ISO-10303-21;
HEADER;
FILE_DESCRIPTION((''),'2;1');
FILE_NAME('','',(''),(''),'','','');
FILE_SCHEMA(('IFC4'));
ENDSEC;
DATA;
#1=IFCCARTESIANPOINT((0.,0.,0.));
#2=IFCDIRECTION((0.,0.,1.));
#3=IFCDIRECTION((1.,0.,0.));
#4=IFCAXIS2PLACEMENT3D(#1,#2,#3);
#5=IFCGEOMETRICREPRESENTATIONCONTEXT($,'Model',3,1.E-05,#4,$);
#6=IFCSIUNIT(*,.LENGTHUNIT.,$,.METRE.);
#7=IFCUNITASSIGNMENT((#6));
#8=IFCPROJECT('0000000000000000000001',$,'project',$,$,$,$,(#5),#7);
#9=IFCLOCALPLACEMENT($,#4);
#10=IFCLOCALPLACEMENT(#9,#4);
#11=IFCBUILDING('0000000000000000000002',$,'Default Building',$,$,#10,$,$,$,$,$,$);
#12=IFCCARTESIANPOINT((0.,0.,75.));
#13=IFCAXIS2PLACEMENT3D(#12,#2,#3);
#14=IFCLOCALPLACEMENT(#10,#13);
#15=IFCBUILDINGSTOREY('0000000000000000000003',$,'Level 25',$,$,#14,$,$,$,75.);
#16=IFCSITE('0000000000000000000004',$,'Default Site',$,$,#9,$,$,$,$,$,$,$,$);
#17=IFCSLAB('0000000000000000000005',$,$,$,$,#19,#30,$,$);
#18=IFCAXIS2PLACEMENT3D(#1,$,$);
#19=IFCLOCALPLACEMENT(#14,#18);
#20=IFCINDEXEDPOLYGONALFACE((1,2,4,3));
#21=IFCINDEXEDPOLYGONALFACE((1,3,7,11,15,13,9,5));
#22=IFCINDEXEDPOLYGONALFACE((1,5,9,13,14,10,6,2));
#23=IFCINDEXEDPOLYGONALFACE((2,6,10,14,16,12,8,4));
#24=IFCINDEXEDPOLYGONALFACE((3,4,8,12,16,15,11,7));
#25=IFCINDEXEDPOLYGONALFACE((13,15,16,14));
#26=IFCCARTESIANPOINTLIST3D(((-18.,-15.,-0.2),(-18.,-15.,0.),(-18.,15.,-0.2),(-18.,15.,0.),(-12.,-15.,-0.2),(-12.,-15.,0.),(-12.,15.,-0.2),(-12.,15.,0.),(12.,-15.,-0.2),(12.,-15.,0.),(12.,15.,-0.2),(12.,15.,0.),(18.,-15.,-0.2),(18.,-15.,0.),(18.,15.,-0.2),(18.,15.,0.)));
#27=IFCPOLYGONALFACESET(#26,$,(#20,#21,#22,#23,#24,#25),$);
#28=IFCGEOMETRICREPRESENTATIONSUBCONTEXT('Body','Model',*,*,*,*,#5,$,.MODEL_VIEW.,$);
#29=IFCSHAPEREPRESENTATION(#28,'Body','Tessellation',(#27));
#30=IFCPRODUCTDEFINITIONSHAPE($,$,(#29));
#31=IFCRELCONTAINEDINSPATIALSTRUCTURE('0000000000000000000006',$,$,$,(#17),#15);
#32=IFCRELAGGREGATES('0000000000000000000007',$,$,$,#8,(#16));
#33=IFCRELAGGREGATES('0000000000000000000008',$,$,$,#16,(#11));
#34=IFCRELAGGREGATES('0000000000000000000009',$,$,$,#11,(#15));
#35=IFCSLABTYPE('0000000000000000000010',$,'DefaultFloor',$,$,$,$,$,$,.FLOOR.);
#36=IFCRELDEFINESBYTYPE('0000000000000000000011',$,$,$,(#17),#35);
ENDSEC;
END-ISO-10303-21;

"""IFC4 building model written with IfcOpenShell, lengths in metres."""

from ifc_helpers import new_model, si_unit, frame, origin_with_axes, place, context, subcontext, project, spatial, polyline, outline, extrude, type_object, element, save


model = new_model("IFC4")

# Units and contexts
model_context = context("Model", 3, precision=1e-05, world=origin_with_axes())
body_context = subcontext(model_context, "Body", "Model", "MODEL_VIEW")
ifc_project = project(units=[si_unit("LENGTHUNIT", "METRE")], contexts=[model_context])

# Site, building, storey
site_placement = place(None, origin_with_axes())
site = spatial("IfcSite", under=ifc_project, at=site_placement, Name="Default Site")
building_placement = place(site_placement, origin_with_axes())
building = spatial("IfcBuilding", under=site, at=building_placement, Name="Default Building")
storey_placement = place(building_placement, frame((0.0, 0.0, 75.0), z_axis=(0.0, 0.0, 1.0), x_axis=(1.0, 0.0, 0.0)))
storey = spatial("IfcBuildingStorey", under=building, at=storey_placement, Name="Level 25", Elevation=75.0)

# Slab
slab_type = type_object("IfcSlabType", Name="DefaultFloor", PredefinedType="FLOOR")
slab_placement = place(storey_placement, frame((0.0, 0.0, -75.0), z_axis=(0.0, 0.0, 1.0), x_axis=(1.0, 0.0, 0.0)))
element("IfcSlab", 1, at=slab_placement, inside=storey, type_object=slab_type, context=body_context, shape_type="SweptSolid", body=[
    extrude(outline(polyline([(-18.0, 15.0), (-12.0, 15.0), (12.0, 15.0), (18.0, 15.0), (18.0, -15.0), (12.0, -15.0), (-12.0, -15.0), (-18.0, -15.0), (-18.0, 15.0)])), frame((0.0, 0.0, 75.0), z_axis=(0.0, 0.0, 1.0), x_axis=(1.0, 0.0, 0.0)), (0.0, 0.0, -1.0), 0.2),
])

save(model, "model.ifc")
